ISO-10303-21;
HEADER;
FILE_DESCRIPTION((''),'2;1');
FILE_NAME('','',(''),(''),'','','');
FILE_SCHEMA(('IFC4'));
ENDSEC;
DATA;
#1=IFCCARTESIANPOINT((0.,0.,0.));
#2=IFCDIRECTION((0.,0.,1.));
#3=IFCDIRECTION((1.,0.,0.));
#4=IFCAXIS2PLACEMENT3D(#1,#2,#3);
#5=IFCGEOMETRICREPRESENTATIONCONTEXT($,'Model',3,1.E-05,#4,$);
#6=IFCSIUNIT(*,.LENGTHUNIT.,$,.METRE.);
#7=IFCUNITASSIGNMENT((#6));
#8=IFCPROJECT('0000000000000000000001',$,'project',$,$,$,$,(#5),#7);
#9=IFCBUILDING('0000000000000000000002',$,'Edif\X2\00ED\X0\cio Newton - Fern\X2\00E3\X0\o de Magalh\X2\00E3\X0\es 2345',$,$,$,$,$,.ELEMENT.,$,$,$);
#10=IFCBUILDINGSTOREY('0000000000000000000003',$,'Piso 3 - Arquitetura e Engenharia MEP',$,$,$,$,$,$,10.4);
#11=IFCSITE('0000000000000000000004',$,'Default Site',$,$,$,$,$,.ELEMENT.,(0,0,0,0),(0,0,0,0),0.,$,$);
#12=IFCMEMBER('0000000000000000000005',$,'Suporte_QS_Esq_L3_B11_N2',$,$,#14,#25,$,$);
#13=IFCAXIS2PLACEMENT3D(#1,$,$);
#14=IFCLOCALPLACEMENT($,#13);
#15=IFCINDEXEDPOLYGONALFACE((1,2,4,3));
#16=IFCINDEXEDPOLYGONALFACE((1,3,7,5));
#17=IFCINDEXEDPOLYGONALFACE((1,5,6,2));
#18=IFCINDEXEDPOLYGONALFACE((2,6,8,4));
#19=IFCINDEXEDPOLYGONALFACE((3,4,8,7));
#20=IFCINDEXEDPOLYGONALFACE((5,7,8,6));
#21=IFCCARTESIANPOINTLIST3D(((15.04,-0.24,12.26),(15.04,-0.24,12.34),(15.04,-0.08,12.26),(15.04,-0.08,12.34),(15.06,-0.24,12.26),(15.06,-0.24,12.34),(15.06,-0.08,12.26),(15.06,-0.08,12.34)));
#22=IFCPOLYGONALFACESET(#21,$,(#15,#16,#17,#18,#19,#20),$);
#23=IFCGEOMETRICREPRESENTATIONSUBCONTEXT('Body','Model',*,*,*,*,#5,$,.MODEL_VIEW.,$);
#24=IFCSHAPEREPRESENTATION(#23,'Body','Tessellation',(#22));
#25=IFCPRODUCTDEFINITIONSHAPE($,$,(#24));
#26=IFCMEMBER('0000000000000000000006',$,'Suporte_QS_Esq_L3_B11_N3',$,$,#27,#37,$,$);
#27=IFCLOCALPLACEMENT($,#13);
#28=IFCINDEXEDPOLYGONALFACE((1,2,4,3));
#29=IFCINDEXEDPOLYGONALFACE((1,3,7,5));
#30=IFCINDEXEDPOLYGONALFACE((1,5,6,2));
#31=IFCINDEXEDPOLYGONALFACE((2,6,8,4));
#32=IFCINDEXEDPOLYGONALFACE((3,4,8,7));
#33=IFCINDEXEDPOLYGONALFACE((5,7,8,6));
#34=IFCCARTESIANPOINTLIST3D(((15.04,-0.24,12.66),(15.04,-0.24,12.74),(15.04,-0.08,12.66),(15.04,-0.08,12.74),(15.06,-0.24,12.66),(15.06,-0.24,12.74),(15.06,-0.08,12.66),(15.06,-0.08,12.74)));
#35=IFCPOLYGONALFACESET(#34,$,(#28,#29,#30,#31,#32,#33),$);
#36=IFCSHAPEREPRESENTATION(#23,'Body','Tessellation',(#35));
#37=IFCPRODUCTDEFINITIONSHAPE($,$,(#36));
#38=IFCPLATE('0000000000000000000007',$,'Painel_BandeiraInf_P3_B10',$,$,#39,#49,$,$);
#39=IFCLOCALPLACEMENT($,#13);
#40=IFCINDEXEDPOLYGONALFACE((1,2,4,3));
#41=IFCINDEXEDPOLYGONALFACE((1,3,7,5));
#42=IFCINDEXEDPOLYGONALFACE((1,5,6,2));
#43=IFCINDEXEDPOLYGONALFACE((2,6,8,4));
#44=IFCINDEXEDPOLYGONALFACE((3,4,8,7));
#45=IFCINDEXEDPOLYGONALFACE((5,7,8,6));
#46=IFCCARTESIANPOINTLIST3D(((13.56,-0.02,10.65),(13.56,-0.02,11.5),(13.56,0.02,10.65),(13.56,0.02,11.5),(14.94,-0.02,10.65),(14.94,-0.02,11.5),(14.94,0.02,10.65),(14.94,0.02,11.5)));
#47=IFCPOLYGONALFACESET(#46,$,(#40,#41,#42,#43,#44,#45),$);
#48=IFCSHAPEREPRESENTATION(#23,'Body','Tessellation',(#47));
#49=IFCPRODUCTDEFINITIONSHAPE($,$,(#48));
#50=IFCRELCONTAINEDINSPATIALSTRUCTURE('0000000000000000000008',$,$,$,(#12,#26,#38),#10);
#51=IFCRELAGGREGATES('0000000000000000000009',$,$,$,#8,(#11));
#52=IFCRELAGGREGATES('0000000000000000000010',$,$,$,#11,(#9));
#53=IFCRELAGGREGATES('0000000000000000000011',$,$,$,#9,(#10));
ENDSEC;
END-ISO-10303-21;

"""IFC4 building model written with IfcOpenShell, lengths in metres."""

from ifc_helpers import new_model, si_unit, frame, frame_2d, origin_with_axes, place, context, subcontext, project, spatial, rectangle, extrude, element, save


model = new_model("IFC4")

# Units and contexts
model_context = context("Model", 3, precision=1e-05, world=origin_with_axes())
body_context = subcontext(model_context, "Body", "Model", "MODEL_VIEW")
ifc_project = project(units=[si_unit("LENGTHUNIT", "METRE")], contexts=[model_context])

# Site, building, storey
site = spatial("IfcSite", under=ifc_project, Name="Default Site", CompositionType="ELEMENT", RefLatitude=(0, 0, 0, 0), RefLongitude=(0, 0, 0, 0), RefElevation=0.0)
building = spatial("IfcBuilding", under=site, Name="Edifício Newton - Fernão de Magalhães 2345", CompositionType="ELEMENT")
storey = spatial("IfcBuildingStorey", under=building, Name="Piso 3 - Arquitetura e Engenharia MEP", Elevation=10.4)

# Members
for number, where, z_axis, x_axis, name in (
    (1, (15.04, -0.24, 12.26), (0.0, 0.0, 1.0), (1.0, 0.0, 0.0), "Suporte_QS_Esq_L3_B11_N2"),
    (2, (15.04, -0.24, 12.66), (0.0, 0.0, 1.0), (1.0, 0.0, 0.0), "Suporte_QS_Esq_L3_B11_N3"),
):
    element("IfcMember", number, at=place(None, frame(where, z_axis=z_axis, x_axis=x_axis)), inside=storey, Name=name, context=body_context, shape_type="SweptSolid", body=[
        extrude(rectangle(XDim=0.02, YDim=0.16, at=frame_2d((0.01, 0.08))), origin_with_axes(), (0.0, 0.0, 1.0), 0.08),
    ])

# Plate
plate_placement = place(None, frame((13.56, -0.02, 10.65), z_axis=(0.0, 0.0, 1.0), x_axis=(1.0, 0.0, 0.0)))
element("IfcPlate", 3, at=plate_placement, inside=storey, Name="Painel_BandeiraInf_P3_B10", context=body_context, shape_type="SweptSolid", body=[
    extrude(rectangle(XDim=1.38, YDim=0.04, at=frame_2d((0.69, 0.02))), origin_with_axes(), (0.0, 0.0, 1.0), 0.85),
])

save(model, "model.ifc")
